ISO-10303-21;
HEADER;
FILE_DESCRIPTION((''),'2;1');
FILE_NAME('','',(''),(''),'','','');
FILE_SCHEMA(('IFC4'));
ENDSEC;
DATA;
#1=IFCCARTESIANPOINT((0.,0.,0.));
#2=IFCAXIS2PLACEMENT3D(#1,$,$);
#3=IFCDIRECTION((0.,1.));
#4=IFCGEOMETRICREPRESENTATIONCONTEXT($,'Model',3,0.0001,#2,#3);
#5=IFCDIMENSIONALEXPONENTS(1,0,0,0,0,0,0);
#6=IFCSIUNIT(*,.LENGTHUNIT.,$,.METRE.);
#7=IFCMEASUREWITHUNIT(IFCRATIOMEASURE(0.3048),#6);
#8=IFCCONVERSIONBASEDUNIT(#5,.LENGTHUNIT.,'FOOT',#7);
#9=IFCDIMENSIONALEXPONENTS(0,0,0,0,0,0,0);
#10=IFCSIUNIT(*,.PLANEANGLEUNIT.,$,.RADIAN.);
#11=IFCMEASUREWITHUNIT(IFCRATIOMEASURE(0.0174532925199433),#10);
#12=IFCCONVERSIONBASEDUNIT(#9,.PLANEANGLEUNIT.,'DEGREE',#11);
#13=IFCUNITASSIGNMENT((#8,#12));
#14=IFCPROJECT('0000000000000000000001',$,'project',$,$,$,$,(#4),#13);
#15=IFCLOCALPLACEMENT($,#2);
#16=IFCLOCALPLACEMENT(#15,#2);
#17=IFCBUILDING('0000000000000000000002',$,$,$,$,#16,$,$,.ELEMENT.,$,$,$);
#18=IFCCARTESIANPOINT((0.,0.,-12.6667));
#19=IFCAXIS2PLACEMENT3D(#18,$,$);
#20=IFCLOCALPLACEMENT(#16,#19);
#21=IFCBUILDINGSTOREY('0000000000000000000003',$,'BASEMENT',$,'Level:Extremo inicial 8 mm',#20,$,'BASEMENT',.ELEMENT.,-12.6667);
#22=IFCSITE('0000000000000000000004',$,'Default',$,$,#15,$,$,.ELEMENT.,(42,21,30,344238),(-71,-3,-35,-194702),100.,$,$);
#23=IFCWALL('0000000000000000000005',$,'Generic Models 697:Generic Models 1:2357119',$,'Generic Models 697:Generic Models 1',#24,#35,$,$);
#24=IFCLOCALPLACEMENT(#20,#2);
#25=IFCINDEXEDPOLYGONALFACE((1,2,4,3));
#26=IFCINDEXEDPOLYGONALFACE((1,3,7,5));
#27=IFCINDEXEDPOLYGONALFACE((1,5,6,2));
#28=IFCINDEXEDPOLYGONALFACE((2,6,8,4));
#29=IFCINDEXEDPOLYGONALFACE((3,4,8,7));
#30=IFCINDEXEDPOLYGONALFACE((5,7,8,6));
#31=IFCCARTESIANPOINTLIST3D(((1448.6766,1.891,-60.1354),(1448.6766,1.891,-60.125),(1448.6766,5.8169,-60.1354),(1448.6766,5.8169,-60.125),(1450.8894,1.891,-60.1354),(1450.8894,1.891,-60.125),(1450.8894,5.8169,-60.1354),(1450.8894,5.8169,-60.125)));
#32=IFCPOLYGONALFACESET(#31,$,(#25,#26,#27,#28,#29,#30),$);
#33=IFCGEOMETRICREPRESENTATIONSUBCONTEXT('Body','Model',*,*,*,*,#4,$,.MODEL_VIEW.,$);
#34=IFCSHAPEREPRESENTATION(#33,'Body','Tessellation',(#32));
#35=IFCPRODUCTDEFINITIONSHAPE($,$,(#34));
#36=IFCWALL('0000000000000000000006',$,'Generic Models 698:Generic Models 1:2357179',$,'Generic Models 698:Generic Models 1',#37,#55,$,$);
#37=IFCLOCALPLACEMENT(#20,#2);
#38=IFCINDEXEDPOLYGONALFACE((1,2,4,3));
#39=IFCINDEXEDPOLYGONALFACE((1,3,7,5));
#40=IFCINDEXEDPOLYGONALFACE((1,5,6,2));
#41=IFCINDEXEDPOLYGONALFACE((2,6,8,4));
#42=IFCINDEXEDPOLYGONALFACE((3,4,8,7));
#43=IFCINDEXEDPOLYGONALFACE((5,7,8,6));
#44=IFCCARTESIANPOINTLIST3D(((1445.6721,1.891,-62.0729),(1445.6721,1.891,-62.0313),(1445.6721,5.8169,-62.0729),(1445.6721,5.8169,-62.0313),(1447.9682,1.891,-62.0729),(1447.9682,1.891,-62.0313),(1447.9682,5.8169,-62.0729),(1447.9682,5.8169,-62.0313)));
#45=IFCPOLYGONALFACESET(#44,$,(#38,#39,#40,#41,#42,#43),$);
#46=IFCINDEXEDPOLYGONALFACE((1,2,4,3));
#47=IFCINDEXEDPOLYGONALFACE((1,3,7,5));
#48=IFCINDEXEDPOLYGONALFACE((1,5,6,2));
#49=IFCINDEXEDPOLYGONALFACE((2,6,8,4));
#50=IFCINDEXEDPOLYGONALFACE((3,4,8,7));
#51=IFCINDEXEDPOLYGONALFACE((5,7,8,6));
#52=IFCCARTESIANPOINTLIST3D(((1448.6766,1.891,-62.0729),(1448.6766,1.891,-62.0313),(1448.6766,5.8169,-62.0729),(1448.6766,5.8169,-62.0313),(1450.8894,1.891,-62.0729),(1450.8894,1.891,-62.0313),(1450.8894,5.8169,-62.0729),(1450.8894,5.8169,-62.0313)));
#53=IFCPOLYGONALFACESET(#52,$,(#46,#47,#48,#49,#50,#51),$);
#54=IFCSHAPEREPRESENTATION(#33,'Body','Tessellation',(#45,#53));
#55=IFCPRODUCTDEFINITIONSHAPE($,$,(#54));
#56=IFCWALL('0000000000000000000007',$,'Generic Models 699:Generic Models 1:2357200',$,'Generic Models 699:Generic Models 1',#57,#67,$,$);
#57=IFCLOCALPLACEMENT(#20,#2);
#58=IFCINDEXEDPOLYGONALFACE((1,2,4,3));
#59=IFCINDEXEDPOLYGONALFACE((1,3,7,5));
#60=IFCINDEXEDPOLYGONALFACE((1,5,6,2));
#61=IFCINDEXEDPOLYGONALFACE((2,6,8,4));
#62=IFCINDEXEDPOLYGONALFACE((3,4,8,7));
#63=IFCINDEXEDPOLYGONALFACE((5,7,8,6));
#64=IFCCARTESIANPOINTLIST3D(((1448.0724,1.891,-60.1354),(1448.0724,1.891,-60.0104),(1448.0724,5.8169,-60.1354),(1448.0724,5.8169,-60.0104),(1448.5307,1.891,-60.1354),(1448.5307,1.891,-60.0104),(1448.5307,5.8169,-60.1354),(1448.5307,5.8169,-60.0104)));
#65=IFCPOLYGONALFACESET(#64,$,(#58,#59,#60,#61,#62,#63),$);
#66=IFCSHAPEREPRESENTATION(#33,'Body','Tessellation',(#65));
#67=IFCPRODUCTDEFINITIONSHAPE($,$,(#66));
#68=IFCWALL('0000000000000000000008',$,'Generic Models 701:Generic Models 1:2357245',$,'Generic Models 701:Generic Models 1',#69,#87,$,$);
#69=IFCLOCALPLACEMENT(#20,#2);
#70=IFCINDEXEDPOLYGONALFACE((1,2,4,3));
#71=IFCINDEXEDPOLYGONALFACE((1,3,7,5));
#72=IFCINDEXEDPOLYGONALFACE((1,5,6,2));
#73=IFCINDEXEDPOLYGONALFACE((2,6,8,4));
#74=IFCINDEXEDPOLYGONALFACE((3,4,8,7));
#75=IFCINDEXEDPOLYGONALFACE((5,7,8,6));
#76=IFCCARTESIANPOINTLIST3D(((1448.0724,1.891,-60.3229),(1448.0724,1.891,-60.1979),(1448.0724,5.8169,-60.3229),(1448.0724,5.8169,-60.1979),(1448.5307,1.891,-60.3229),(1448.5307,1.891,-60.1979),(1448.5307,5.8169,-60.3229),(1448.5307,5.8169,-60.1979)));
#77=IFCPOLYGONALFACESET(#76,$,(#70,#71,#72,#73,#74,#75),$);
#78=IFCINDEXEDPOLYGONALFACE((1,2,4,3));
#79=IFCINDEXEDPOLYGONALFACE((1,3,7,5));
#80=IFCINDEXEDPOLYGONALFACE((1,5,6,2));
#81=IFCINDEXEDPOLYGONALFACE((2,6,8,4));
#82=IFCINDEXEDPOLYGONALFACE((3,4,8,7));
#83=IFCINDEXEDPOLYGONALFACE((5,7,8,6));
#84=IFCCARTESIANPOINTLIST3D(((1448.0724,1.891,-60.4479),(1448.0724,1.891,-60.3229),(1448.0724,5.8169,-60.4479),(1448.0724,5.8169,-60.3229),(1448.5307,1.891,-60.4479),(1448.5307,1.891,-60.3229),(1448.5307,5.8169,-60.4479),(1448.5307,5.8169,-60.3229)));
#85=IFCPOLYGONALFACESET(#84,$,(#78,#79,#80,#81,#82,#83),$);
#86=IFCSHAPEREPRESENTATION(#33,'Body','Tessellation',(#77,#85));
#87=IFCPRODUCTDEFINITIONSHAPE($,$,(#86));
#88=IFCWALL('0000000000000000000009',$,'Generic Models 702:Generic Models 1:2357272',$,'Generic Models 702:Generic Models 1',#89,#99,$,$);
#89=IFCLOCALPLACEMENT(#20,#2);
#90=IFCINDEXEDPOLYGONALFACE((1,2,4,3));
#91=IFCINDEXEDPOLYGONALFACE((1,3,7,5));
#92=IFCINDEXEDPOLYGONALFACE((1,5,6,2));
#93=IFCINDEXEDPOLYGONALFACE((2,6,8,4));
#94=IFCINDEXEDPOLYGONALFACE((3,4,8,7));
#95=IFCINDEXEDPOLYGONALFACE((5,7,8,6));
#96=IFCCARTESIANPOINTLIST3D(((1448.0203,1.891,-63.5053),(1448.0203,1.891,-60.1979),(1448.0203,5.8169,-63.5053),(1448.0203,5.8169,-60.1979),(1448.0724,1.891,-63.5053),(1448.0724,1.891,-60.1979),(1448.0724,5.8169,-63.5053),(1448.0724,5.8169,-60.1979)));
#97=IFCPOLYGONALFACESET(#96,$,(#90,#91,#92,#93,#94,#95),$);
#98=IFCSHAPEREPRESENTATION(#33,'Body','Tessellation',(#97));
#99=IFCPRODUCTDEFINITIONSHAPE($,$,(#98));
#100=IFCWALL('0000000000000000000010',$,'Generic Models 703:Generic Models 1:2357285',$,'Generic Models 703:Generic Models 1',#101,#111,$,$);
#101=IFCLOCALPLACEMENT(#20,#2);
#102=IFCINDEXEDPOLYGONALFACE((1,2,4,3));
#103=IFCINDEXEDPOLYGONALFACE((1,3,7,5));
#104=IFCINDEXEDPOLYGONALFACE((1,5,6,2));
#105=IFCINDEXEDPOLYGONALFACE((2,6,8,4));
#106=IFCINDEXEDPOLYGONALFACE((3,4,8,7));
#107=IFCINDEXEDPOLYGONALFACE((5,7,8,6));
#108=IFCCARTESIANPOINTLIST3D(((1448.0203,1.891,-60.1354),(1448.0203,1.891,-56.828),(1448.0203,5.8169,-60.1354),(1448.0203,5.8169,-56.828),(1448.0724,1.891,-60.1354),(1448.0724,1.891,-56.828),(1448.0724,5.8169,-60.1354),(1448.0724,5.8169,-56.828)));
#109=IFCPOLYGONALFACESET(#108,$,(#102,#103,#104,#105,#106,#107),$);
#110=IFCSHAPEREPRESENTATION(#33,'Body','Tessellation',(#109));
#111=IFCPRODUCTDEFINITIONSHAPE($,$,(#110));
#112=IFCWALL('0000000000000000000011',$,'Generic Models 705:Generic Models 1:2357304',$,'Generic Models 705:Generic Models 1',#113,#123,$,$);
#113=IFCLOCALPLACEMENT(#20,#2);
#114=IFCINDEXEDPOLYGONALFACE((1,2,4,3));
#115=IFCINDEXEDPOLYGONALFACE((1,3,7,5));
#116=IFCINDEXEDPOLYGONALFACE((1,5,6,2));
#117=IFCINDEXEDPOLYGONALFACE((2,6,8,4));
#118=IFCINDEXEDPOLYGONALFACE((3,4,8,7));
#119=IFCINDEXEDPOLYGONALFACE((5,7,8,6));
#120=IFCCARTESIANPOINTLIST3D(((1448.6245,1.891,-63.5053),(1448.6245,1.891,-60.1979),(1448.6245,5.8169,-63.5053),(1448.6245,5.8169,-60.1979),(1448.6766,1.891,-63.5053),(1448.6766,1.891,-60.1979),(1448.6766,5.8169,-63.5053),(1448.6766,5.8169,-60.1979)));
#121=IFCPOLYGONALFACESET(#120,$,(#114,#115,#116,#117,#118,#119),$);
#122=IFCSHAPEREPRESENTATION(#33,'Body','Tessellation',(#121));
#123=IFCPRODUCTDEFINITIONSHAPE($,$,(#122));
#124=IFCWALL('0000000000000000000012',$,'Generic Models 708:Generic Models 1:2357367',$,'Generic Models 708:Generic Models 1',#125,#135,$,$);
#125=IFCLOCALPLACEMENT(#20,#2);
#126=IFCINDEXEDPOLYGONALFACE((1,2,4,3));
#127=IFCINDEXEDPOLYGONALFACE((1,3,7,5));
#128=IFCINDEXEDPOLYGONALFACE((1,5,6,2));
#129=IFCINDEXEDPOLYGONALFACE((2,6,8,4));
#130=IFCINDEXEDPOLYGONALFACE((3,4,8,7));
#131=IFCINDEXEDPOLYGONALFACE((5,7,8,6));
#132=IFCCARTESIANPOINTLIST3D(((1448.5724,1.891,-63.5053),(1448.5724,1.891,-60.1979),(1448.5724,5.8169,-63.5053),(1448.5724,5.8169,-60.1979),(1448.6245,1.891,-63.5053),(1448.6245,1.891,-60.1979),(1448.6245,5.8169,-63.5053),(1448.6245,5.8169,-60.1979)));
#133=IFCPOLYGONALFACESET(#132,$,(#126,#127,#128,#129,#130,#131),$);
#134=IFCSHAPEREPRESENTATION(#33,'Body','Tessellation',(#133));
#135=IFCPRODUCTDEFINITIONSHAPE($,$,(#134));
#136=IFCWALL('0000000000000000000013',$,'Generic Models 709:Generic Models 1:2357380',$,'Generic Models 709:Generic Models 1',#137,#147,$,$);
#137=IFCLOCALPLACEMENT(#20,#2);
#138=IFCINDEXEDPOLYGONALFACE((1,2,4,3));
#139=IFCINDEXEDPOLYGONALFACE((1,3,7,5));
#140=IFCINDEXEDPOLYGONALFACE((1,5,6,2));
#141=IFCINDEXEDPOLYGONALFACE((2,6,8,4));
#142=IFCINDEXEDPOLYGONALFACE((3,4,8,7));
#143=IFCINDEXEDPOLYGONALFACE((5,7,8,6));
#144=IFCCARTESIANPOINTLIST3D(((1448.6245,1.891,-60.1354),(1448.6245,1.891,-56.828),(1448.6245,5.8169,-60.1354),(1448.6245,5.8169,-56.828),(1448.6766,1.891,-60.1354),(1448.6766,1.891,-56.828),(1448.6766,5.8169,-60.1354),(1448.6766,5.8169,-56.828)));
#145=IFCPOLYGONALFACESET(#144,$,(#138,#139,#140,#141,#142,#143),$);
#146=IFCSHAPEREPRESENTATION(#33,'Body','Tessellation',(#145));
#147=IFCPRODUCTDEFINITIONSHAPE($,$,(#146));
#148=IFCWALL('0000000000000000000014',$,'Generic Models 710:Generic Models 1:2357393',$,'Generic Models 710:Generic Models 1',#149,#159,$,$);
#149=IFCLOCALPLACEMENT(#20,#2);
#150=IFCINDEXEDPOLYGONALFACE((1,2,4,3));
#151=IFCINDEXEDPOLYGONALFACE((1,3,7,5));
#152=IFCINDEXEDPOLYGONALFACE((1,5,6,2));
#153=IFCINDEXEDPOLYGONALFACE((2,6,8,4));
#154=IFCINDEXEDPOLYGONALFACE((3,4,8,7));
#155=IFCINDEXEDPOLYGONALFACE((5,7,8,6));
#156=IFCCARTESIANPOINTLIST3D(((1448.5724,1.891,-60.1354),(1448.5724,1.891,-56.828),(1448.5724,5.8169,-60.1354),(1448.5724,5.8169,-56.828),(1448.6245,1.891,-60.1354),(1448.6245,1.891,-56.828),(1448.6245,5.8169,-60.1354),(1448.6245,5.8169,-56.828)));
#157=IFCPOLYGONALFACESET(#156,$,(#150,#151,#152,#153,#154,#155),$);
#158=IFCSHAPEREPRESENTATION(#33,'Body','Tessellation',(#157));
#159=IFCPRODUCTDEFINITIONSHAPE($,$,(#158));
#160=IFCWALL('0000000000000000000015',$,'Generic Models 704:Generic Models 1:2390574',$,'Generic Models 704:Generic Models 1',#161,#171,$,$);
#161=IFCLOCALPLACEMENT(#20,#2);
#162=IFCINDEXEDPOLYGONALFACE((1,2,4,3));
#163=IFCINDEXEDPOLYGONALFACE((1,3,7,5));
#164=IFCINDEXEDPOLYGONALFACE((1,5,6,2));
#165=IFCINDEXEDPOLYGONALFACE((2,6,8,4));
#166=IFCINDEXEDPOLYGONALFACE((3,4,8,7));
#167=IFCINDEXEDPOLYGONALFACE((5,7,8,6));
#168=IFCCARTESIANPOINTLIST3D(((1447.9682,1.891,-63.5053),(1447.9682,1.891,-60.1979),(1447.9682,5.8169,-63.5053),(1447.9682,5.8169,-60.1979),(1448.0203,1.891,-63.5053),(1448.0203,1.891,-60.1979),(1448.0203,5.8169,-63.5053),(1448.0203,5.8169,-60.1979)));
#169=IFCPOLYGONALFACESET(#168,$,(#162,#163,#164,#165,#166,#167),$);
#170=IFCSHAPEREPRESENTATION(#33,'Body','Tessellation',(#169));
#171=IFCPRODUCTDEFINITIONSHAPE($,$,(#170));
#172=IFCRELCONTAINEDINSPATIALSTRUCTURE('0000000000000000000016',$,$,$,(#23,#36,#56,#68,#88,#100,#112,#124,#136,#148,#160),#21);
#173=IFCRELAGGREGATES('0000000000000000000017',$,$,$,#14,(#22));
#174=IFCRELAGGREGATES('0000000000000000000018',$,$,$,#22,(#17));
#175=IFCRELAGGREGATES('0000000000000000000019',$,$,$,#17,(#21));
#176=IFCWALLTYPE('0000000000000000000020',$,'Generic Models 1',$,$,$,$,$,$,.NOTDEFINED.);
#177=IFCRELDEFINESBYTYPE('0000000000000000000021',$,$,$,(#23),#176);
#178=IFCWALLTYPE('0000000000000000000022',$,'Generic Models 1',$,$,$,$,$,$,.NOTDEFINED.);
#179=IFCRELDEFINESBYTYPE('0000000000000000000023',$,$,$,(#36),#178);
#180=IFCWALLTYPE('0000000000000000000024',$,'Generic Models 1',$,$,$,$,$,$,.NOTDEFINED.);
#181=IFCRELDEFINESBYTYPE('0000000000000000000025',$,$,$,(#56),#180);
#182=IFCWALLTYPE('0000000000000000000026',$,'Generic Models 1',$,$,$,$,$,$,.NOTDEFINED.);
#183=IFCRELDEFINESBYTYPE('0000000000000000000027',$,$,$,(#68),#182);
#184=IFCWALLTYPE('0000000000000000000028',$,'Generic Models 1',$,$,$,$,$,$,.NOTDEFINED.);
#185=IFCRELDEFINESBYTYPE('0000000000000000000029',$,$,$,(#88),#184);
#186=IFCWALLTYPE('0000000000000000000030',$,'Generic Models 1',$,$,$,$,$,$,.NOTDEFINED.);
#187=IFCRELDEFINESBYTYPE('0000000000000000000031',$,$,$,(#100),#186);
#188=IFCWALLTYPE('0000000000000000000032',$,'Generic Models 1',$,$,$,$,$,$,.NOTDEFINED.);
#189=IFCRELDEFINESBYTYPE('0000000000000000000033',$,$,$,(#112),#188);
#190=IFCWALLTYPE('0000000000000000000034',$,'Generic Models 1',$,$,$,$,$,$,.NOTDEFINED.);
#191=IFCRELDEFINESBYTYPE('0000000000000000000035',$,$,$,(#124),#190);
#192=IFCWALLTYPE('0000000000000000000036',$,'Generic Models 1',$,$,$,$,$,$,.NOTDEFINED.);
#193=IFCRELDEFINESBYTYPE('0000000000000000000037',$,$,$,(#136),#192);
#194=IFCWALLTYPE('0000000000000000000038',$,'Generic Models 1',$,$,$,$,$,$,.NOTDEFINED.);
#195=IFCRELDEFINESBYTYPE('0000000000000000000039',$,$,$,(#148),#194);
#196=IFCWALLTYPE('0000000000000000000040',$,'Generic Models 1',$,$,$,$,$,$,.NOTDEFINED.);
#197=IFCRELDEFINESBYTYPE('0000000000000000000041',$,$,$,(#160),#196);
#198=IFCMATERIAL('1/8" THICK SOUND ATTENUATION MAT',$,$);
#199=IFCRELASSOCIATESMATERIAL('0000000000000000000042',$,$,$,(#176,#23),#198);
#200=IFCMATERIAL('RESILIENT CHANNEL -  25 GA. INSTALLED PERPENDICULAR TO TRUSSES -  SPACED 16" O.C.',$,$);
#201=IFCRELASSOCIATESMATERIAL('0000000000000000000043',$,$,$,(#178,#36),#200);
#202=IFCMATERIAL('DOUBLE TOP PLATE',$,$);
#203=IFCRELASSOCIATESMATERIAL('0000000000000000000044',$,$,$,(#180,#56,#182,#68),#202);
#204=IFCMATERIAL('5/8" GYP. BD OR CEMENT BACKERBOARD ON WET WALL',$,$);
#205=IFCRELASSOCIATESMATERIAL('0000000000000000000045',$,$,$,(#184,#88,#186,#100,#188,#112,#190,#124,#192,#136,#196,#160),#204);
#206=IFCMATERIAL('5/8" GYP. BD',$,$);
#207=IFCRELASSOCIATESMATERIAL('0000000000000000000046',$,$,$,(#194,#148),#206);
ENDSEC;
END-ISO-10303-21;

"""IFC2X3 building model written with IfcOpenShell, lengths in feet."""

from ifc_helpers import new_model, entity, si_unit, converted_unit, direction, frame, frame_2d, origin, place, context, subcontext, project, spatial, rectangle, extrude, material, type_object, element, save


model = new_model("IFC2X3")

# Units and contexts
model_context = context("Model", 3, precision=0.0001, world=origin(), true_north=direction((0.0, 1.0)))
body_context = subcontext(model_context, "Body", "Model", "MODEL_VIEW")
ifc_project = project(units=[converted_unit("LENGTHUNIT", "FOOT", entity("IfcRatioMeasure", 0.3048), si_unit("LENGTHUNIT", "METRE"), dimensions=[1, 0, 0, 0, 0, 0, 0]), converted_unit("PLANEANGLEUNIT", "DEGREE", entity("IfcRatioMeasure", 0.0174532925199433), si_unit("PLANEANGLEUNIT", "RADIAN"), dimensions=[0, 0, 0, 0, 0, 0, 0])], contexts=[model_context])

# Site, building, storey
site_placement = place(None, origin())
site = spatial("IfcSite", under=ifc_project, at=site_placement, Name="Default", CompositionType="ELEMENT", RefLatitude=(42, 21, 30, 344238), RefLongitude=(-71, -3, -35, -194702), RefElevation=100.0)
building_placement = place(site_placement, origin())
building = spatial("IfcBuilding", under=site, at=building_placement, CompositionType="ELEMENT")
storey_placement = place(building_placement, frame((0.0, 0.0, -12.6667)))
storey = spatial("IfcBuildingStorey", under=building, at=storey_placement, Name="BASEMENT", ObjectType="Level:Extremo inicial 8 mm", LongName="BASEMENT", CompositionType="ELEMENT", Elevation=-12.6667)

# Walls
ifc_material_1 = material(Name="1/8\" THICK SOUND ATTENUATION MAT")
wall_type_1 = type_object("IfcWallType", Name="Generic Models 1", PredefinedType="NOTDEFINED", material=ifc_material_1)
wall_1_placement = place(storey_placement, frame((1448.6766, 1.891, -60.1354), z_axis=(0.0, 0.0, 1.0), x_axis=(0.0, 1.0, 0.0)))
element("IfcWall", 1, at=wall_1_placement, inside=storey, type_object=wall_type_1, material=ifc_material_1, Name="Generic Models 697:Generic Models 1:2357119", ObjectType="Generic Models 697:Generic Models 1", context=body_context, shape_type="SweptSolid", body=[
    extrude(rectangle(XDim=3.9258, YDim=2.2128, at=frame_2d((0.0, 0.0), x_axis=(1.0, 0.0))), frame((1.9629, -1.1064, 0.0)), (0.0, 0.0, 1.0), 0.0104),
])
ifc_material_2 = material(Name="RESILIENT CHANNEL -  25 GA. INSTALLED PERPENDICULAR TO TRUSSES -  SPACED 16\" O.C.")
wall_type_2 = type_object("IfcWallType", Name="Generic Models 1", PredefinedType="NOTDEFINED", material=ifc_material_2)
wall_2_placement = place(storey_placement, frame((1445.6721, 1.891, -62.0729)))
element("IfcWall", 2, at=wall_2_placement, inside=storey, type_object=wall_type_2, material=ifc_material_2, Name="Generic Models 698:Generic Models 1:2357179", ObjectType="Generic Models 698:Generic Models 1", context=body_context, shape_type="SweptSolid", body=[
    extrude(rectangle(XDim=3.9258, YDim=2.2962, at=frame_2d((0.0, 0.0), x_axis=(1.0, 0.0))), frame((1.1481, 1.9629, 0.0), z_axis=(0.0, 0.0, 1.0), x_axis=(0.0, 1.0, 0.0)), (0.0, 0.0, 1.0), 0.0417),
    extrude(rectangle(XDim=3.9258, YDim=2.2128, at=frame_2d((0.0, 0.0), x_axis=(1.0, 0.0))), frame((4.1109, 1.9629, 0.0), z_axis=(0.0, 0.0, 1.0), x_axis=(0.0, 1.0, 0.0)), (0.0, 0.0, 1.0), 0.0417),
])
ifc_material_3 = material(Name="DOUBLE TOP PLATE")
wall_type_3 = type_object("IfcWallType", Name="Generic Models 1", PredefinedType="NOTDEFINED", material=ifc_material_3)
wall_3_placement = place(storey_placement, frame((1448.0724, 1.891, -60.1354), z_axis=(0.0, 0.0, 1.0), x_axis=(0.0, 1.0, 0.0)))
element("IfcWall", 3, at=wall_3_placement, inside=storey, type_object=wall_type_3, material=ifc_material_3, Name="Generic Models 699:Generic Models 1:2357200", ObjectType="Generic Models 699:Generic Models 1", context=body_context, shape_type="SweptSolid", body=[
    extrude(rectangle(XDim=3.9258, YDim=0.4583, at=frame_2d((0.0, 0.0), x_axis=(1.0, 0.0))), frame((1.9629, -0.2292, 0.0)), (0.0, 0.0, 1.0), 0.125),
])
wall_type_4 = type_object("IfcWallType", Name="Generic Models 1", PredefinedType="NOTDEFINED", material=ifc_material_3)
wall_4_placement = place(storey_placement, frame((1448.0724, 1.891, -60.4479), z_axis=(0.0, 0.0, 1.0), x_axis=(0.0, 1.0, 0.0)))
element("IfcWall", 4, at=wall_4_placement, inside=storey, type_object=wall_type_4, material=ifc_material_3, Name="Generic Models 701:Generic Models 1:2357245", ObjectType="Generic Models 701:Generic Models 1", context=body_context, shape_type="SweptSolid", body=[
    extrude(rectangle(XDim=3.9258, YDim=0.4583, at=frame_2d((0.0, 0.0), x_axis=(1.0, 0.0))), frame((1.9629, -0.2292, 0.125)), (0.0, 0.0, 1.0), 0.125),
    extrude(rectangle(XDim=3.9258, YDim=0.4583, at=frame_2d((0.0, 0.0), x_axis=(1.0, 0.0))), frame((1.9629, -0.2292, 0.0)), (0.0, 0.0, 1.0), 0.125),
])
ifc_material_4 = material(Name="5/8\" GYP. BD OR CEMENT BACKERBOARD ON WET WALL")
wall_type_5 = type_object("IfcWallType", Name="Generic Models 1", PredefinedType="NOTDEFINED", material=ifc_material_4)
wall_5_placement = place(storey_placement, frame((1448.0203, 1.891, -63.5053), z_axis=(0.0, 0.0, 1.0), x_axis=(0.0, 1.0, 0.0)))
element("IfcWall", 5, at=wall_5_placement, inside=storey, type_object=wall_type_5, material=ifc_material_4, Name="Generic Models 702:Generic Models 1:2357272", ObjectType="Generic Models 702:Generic Models 1", context=body_context, shape_type="SweptSolid", body=[
    extrude(rectangle(XDim=3.9258, YDim=0.0521, at=frame_2d((0.0, 0.0), x_axis=(1.0, 0.0))), frame((1.9629, -0.026, 0.0)), (0.0, 0.0, 1.0), 3.3074),
])
wall_type_6 = type_object("IfcWallType", Name="Generic Models 1", PredefinedType="NOTDEFINED", material=ifc_material_4)
wall_6_placement = place(storey_placement, frame((1448.0203, 1.891, -60.1354), z_axis=(0.0, 0.0, 1.0), x_axis=(0.0, 1.0, 0.0)))
element("IfcWall", 6, at=wall_6_placement, inside=storey, type_object=wall_type_6, material=ifc_material_4, Name="Generic Models 703:Generic Models 1:2357285", ObjectType="Generic Models 703:Generic Models 1", context=body_context, shape_type="SweptSolid", body=[
    extrude(rectangle(XDim=3.9258, YDim=0.0521, at=frame_2d((0.0, 0.0), x_axis=(1.0, 0.0))), frame((1.9629, -0.026, 0.0)), (0.0, 0.0, 1.0), 3.3074),
])
wall_type_7 = type_object("IfcWallType", Name="Generic Models 1", PredefinedType="NOTDEFINED", material=ifc_material_4)
wall_7_placement = place(storey_placement, frame((1448.6245, 1.891, -63.5053), z_axis=(0.0, 0.0, 1.0), x_axis=(0.0, 1.0, 0.0)))
element("IfcWall", 7, at=wall_7_placement, inside=storey, type_object=wall_type_7, material=ifc_material_4, Name="Generic Models 705:Generic Models 1:2357304", ObjectType="Generic Models 705:Generic Models 1", context=body_context, shape_type="SweptSolid", body=[
    extrude(rectangle(XDim=3.9258, YDim=0.0521, at=frame_2d((0.0, 0.0), x_axis=(1.0, 0.0))), frame((1.9629, -0.026, 0.0)), (0.0, 0.0, 1.0), 3.3074),
])
wall_type_8 = type_object("IfcWallType", Name="Generic Models 1", PredefinedType="NOTDEFINED", material=ifc_material_4)
wall_8_placement = place(storey_placement, frame((1448.5724, 1.891, -63.5053), z_axis=(0.0, 0.0, 1.0), x_axis=(0.0, 1.0, 0.0)))
element("IfcWall", 8, at=wall_8_placement, inside=storey, type_object=wall_type_8, material=ifc_material_4, Name="Generic Models 708:Generic Models 1:2357367", ObjectType="Generic Models 708:Generic Models 1", context=body_context, shape_type="SweptSolid", body=[
    extrude(rectangle(XDim=3.9258, YDim=0.0521, at=frame_2d((0.0, 0.0), x_axis=(1.0, 0.0))), frame((1.9629, -0.026, 0.0)), (0.0, 0.0, 1.0), 3.3074),
])
wall_type_9 = type_object("IfcWallType", Name="Generic Models 1", PredefinedType="NOTDEFINED", material=ifc_material_4)
wall_9_placement = place(storey_placement, frame((1448.6245, 1.891, -60.1354), z_axis=(0.0, 0.0, 1.0), x_axis=(0.0, 1.0, 0.0)))
element("IfcWall", 9, at=wall_9_placement, inside=storey, type_object=wall_type_9, material=ifc_material_4, Name="Generic Models 709:Generic Models 1:2357380", ObjectType="Generic Models 709:Generic Models 1", context=body_context, shape_type="SweptSolid", body=[
    extrude(rectangle(XDim=3.9258, YDim=0.0521, at=frame_2d((0.0, 0.0), x_axis=(1.0, 0.0))), frame((1.9629, -0.026, 0.0)), (0.0, 0.0, 1.0), 3.3074),
])
ifc_material_5 = material(Name="5/8\" GYP. BD")
wall_type_10 = type_object("IfcWallType", Name="Generic Models 1", PredefinedType="NOTDEFINED", material=ifc_material_5)
wall_10_placement = place(storey_placement, frame((1448.5724, 1.891, -60.1354), z_axis=(0.0, 0.0, 1.0), x_axis=(0.0, 1.0, 0.0)))
element("IfcWall", 10, at=wall_10_placement, inside=storey, type_object=wall_type_10, material=ifc_material_5, Name="Generic Models 710:Generic Models 1:2357393", ObjectType="Generic Models 710:Generic Models 1", context=body_context, shape_type="SweptSolid", body=[
    extrude(rectangle(XDim=3.9258, YDim=0.0521, at=frame_2d((0.0, 0.0), x_axis=(1.0, 0.0))), frame((1.9629, -0.026, 0.0)), (0.0, 0.0, 1.0), 3.3074),
])
wall_type_11 = type_object("IfcWallType", Name="Generic Models 1", PredefinedType="NOTDEFINED", material=ifc_material_4)
wall_11_placement = place(storey_placement, frame((1447.9682, 1.891, -63.5053), z_axis=(0.0, 0.0, 1.0), x_axis=(0.0, 1.0, 0.0)))
element("IfcWall", 11, at=wall_11_placement, inside=storey, type_object=wall_type_11, material=ifc_material_4, Name="Generic Models 704:Generic Models 1:2390574", ObjectType="Generic Models 704:Generic Models 1", context=body_context, shape_type="SweptSolid", body=[
    extrude(rectangle(XDim=3.9258, YDim=0.0521, at=frame_2d((0.0, 0.0), x_axis=(1.0, 0.0))), frame((1.9629, -0.026, 0.0)), (0.0, 0.0, 1.0), 3.3074),
])

save(model, "model.ifc")
